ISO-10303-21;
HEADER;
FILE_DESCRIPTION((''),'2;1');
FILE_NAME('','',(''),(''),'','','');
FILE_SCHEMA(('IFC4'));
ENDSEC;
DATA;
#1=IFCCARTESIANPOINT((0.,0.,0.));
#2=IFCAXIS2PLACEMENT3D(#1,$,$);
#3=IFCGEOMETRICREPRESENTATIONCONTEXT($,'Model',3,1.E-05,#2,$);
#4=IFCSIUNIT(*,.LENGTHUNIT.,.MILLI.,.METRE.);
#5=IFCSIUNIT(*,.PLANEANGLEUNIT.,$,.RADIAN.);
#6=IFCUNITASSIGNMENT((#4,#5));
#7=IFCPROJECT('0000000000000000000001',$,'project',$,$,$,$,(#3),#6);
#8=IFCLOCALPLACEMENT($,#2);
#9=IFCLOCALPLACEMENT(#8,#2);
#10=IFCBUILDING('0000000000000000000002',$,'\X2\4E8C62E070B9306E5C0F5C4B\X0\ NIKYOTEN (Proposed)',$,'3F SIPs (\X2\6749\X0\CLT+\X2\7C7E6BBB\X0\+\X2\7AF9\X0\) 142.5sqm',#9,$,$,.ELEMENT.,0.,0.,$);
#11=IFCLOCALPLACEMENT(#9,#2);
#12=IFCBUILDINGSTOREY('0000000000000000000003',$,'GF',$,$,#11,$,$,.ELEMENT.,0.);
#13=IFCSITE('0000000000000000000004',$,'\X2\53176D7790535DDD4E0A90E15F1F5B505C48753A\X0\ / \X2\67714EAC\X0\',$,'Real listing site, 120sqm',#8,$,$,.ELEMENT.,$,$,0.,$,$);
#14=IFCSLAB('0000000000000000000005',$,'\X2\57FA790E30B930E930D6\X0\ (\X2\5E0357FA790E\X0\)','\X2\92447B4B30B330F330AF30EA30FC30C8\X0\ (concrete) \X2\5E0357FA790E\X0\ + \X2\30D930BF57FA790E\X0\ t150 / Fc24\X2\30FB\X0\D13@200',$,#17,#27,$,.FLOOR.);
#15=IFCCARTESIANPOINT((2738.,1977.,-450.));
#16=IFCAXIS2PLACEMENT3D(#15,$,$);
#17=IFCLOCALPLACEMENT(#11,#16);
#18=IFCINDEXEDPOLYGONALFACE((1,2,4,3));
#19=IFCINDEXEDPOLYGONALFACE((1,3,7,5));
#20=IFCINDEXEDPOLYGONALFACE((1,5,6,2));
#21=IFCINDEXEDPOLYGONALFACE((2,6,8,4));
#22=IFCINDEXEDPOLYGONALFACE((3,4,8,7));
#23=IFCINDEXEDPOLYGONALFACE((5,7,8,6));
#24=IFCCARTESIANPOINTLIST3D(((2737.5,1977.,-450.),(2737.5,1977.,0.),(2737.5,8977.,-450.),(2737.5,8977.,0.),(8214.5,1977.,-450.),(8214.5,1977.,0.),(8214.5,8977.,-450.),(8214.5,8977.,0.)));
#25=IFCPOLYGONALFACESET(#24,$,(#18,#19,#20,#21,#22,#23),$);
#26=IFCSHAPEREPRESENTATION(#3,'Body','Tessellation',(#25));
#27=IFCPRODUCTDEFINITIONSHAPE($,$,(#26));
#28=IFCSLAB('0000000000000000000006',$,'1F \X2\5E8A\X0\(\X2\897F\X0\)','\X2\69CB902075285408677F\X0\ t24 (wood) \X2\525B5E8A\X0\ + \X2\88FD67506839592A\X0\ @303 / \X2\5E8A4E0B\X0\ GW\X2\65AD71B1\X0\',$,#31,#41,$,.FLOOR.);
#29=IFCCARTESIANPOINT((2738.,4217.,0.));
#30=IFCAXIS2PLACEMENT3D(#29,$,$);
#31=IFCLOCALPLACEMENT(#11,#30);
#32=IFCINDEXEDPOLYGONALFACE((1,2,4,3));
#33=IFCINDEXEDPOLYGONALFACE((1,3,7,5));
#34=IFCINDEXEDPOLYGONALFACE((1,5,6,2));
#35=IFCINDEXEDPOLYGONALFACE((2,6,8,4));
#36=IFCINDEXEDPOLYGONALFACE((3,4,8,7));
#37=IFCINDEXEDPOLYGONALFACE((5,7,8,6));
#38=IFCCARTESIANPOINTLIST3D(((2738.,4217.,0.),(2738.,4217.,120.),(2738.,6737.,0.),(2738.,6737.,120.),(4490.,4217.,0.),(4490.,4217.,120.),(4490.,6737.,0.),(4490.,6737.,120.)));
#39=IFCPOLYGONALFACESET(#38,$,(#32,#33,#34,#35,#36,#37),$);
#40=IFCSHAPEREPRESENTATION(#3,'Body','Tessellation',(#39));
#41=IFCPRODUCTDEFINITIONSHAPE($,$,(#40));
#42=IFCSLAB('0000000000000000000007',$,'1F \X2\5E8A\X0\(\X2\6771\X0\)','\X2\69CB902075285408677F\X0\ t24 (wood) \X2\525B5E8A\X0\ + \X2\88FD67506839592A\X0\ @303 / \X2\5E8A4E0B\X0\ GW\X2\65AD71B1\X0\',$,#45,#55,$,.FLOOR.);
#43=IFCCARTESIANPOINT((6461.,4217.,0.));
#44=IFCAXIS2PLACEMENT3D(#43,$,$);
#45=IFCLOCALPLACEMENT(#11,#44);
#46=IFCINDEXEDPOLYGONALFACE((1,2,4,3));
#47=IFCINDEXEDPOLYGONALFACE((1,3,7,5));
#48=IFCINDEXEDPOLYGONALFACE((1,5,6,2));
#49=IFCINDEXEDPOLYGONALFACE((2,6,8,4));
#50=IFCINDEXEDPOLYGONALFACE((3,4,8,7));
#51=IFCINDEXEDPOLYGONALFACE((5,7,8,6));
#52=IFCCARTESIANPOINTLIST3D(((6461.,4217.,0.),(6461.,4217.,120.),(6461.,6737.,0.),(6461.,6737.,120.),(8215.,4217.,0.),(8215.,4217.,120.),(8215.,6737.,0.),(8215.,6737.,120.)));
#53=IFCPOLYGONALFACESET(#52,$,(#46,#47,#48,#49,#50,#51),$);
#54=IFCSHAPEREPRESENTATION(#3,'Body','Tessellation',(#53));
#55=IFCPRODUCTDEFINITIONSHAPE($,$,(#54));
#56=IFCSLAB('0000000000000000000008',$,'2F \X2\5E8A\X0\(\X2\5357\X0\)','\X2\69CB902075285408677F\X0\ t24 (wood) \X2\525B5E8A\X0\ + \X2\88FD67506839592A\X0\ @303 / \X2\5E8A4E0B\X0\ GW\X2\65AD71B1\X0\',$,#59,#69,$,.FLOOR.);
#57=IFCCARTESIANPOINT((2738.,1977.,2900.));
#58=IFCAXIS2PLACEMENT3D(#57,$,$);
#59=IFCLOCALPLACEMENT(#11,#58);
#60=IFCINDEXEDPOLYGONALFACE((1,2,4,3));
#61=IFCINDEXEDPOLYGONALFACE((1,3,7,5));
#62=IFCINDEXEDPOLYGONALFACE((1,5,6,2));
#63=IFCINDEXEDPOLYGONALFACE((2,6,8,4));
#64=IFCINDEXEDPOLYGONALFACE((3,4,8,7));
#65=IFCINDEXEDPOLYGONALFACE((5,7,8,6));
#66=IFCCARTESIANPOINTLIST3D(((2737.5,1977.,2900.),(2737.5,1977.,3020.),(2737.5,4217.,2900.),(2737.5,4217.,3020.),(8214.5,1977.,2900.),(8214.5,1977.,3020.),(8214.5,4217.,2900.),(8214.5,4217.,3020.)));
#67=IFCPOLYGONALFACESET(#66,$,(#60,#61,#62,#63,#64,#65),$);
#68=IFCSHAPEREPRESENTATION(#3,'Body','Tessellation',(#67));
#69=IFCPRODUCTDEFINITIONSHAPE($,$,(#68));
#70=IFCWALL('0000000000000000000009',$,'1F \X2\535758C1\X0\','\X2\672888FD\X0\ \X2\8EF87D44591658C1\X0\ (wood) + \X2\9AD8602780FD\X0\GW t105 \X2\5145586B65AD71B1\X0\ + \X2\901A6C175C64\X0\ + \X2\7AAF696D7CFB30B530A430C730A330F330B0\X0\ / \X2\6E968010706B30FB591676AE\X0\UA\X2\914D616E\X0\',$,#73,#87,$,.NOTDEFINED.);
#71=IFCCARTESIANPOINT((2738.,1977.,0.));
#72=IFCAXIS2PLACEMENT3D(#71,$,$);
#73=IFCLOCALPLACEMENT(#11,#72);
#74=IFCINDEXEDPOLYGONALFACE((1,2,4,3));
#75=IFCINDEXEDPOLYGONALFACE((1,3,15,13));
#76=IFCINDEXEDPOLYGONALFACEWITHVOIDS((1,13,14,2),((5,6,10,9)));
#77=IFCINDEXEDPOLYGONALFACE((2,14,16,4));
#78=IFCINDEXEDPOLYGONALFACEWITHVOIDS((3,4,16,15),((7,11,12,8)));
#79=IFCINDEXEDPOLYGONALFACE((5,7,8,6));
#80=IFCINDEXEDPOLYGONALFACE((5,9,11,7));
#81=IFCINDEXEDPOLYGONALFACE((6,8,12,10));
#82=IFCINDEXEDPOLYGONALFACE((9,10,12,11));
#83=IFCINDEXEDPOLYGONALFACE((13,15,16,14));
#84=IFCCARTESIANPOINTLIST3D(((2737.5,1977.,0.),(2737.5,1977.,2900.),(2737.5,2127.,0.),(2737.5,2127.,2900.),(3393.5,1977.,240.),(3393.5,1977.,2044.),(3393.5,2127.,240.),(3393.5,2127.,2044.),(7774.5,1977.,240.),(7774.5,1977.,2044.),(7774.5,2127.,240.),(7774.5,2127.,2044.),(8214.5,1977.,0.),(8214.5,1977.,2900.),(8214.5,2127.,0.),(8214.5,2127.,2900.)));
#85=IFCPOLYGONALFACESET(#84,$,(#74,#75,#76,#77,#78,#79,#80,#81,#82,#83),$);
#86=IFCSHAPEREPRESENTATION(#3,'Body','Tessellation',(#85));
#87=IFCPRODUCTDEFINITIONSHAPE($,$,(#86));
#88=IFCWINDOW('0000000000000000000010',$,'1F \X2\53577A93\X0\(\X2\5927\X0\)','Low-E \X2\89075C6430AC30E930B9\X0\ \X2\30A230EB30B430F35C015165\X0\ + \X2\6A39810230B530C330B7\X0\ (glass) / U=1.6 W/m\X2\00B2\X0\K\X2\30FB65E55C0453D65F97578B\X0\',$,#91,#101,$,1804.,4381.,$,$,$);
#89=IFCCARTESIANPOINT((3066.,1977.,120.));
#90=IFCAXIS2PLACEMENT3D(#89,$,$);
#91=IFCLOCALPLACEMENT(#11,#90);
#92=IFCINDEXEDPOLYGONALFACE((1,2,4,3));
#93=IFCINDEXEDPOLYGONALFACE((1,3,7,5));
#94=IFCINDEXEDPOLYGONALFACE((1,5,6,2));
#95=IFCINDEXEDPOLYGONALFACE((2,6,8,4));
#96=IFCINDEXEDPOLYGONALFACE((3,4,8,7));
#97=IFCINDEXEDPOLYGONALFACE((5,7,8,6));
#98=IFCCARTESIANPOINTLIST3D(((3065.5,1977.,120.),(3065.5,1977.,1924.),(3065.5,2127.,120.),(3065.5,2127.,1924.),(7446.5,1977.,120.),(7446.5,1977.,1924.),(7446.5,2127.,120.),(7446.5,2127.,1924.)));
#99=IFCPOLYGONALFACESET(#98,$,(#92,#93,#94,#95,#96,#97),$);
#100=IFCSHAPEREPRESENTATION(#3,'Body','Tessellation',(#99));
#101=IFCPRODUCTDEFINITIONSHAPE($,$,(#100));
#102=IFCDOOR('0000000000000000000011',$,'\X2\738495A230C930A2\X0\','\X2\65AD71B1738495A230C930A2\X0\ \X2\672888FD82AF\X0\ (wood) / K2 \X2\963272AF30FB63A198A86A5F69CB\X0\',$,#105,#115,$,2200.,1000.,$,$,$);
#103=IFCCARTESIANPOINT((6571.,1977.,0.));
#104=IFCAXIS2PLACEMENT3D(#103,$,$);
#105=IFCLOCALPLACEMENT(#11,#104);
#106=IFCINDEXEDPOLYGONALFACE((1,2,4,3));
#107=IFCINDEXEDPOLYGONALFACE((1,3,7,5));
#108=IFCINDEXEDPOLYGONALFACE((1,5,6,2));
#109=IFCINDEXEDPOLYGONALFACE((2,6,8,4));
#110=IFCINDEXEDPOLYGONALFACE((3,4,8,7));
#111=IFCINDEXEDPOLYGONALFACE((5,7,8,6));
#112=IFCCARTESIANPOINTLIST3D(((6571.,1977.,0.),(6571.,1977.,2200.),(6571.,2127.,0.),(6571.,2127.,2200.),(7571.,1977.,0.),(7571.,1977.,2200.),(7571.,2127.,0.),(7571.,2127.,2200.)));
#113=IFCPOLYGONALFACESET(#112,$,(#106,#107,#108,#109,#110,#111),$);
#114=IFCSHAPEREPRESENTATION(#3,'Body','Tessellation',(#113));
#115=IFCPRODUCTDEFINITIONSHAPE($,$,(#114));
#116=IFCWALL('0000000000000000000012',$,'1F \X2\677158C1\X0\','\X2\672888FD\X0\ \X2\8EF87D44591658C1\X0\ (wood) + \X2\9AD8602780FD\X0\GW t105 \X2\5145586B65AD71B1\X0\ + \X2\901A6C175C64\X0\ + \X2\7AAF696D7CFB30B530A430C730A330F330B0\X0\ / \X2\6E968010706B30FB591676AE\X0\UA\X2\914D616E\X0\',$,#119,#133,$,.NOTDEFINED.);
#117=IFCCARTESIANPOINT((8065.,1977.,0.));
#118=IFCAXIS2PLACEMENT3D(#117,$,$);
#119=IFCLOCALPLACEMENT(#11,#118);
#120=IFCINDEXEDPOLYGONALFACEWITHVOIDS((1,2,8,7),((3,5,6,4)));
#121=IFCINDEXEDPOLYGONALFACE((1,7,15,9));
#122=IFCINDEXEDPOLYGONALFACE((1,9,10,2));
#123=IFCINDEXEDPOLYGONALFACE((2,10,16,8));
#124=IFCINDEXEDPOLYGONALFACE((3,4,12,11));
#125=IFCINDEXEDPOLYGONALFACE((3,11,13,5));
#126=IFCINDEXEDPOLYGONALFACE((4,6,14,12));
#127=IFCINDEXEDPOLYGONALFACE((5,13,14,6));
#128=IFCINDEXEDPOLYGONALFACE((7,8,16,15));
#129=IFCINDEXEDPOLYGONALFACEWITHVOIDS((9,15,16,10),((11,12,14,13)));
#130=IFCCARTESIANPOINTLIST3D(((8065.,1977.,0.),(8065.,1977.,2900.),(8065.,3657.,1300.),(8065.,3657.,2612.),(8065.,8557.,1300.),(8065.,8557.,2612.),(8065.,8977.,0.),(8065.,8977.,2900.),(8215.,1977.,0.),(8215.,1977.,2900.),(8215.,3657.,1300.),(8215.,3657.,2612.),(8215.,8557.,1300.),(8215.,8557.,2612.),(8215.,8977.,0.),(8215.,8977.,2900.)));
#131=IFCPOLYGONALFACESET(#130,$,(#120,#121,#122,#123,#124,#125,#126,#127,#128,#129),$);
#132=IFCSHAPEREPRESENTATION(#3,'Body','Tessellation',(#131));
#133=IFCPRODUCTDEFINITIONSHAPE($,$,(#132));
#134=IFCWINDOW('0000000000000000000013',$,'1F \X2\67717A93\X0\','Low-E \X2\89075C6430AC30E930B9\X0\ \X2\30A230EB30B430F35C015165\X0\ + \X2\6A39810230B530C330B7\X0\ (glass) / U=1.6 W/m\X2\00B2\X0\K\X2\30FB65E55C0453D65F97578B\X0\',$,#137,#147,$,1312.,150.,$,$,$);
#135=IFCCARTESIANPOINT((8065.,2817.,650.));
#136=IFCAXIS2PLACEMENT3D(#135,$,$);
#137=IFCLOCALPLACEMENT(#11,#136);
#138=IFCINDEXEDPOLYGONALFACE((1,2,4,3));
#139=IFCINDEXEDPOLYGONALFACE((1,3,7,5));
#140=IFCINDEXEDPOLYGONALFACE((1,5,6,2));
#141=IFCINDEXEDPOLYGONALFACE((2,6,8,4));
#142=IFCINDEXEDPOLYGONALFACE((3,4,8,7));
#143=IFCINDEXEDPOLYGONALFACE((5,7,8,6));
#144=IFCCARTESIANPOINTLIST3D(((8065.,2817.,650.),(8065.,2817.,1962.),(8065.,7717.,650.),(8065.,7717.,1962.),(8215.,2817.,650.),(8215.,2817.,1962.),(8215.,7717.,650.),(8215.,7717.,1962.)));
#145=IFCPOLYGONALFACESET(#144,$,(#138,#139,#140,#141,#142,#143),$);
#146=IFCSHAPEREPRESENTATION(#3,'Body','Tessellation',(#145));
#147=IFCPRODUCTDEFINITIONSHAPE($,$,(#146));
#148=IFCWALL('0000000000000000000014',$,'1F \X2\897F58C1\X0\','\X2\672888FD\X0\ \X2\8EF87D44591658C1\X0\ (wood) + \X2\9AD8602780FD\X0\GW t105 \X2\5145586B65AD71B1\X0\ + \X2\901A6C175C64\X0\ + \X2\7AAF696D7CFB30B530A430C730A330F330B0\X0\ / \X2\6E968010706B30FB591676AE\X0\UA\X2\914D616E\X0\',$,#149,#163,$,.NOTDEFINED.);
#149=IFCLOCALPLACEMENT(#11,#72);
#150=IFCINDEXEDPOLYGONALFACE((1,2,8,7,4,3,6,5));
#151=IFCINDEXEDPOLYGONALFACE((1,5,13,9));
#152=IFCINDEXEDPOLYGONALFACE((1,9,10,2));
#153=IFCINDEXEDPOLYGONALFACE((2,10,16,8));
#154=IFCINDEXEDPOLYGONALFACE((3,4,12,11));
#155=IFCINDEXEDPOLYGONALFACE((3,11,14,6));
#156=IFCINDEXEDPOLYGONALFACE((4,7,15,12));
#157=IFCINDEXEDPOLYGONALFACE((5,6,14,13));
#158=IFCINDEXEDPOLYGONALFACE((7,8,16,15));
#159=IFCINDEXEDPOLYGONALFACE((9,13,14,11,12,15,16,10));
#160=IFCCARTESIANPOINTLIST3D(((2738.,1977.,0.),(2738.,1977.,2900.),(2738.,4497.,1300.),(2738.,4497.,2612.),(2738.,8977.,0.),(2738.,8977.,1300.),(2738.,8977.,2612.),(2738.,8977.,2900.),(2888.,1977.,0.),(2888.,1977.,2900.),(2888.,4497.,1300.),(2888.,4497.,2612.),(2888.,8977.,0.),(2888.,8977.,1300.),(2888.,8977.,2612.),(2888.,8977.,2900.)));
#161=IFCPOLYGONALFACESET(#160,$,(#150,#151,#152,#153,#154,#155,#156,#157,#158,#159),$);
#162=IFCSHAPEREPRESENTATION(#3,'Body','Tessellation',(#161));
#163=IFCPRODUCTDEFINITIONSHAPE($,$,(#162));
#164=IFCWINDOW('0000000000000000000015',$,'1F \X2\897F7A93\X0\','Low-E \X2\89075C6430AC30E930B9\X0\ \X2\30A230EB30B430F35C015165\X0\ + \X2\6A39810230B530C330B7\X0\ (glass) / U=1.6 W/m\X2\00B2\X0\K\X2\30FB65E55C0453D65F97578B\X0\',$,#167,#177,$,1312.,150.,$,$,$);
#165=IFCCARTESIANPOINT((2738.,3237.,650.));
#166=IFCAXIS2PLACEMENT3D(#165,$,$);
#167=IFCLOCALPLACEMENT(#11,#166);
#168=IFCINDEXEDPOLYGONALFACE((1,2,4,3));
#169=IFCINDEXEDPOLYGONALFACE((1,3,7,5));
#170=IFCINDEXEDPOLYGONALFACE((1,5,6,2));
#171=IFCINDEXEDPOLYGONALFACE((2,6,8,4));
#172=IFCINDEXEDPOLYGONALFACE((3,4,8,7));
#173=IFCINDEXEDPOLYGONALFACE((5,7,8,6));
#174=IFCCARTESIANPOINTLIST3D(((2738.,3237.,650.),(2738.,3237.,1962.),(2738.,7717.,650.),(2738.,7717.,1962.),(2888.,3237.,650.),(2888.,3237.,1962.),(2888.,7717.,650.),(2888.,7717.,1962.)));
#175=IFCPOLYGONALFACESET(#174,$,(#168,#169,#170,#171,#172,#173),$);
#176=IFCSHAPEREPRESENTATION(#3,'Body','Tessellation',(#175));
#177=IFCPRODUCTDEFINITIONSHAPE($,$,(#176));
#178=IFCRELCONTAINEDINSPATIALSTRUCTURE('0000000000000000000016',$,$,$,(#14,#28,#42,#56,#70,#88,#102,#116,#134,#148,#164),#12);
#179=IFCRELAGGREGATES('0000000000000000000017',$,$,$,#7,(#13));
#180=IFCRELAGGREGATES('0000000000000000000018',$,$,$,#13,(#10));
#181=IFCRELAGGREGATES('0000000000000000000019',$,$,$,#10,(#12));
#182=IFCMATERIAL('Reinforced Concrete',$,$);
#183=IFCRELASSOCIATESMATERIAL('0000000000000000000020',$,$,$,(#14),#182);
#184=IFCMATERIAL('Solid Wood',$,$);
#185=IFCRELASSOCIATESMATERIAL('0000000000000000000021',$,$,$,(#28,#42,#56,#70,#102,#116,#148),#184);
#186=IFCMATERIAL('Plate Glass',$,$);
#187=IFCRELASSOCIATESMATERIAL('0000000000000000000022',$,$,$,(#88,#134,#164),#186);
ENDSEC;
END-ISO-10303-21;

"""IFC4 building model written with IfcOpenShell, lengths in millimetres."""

from ifc_helpers import new_model, si_unit, frame, frame_2d, origin, place, context, project, spatial, rectangle, extrude, material, element, fill, save


model = new_model("IFC4")

# Units and contexts
model_context = context("Model", 3, precision=1e-05, world=origin())
ifc_project = project(units=[si_unit("LENGTHUNIT", "METRE", prefix="MILLI"), si_unit("PLANEANGLEUNIT", "RADIAN")], contexts=[model_context])

# Site, building, storey
site_placement = place(None, origin())
site = spatial("IfcSite", under=ifc_project, at=site_placement, Name="北海道川上郡弟子屈町 / 東京", ObjectType="Real listing site, 120sqm", CompositionType="ELEMENT", RefElevation=0.0)
building_placement = place(site_placement, origin())
building = spatial("IfcBuilding", under=site, at=building_placement, Name="二拠点の小屋 NIKYOTEN (Proposed)", ObjectType="3F SIPs (杉CLT+籾殻+竹) 142.5sqm", CompositionType="ELEMENT", ElevationOfRefHeight=0.0, ElevationOfTerrain=0.0)
storey_placement = place(building_placement, origin())
storey = spatial("IfcBuildingStorey", under=building, at=storey_placement, Name="GF", CompositionType="ELEMENT", Elevation=0.0)

# Slabs
ifc_material_1 = material(Name="Reinforced Concrete")
slab_1_placement = place(storey_placement, frame((2738.0, 1977.0, -450.0)))
element("IfcSlab", 1, at=slab_1_placement, inside=storey, material=ifc_material_1, Name="基礎スラブ (布基礎)", Description="鉄筋コンクリート (concrete) 布基礎 + ベタ基礎 t150 / Fc24・D13@200", PredefinedType="FLOOR", context=model_context, shape_type="SweptSolid", body=[
    extrude(rectangle(XDim=5477.0, YDim=7000.0, at=frame_2d((2738.0, 3500.0))), frame((2738.0, 1977.0, -450.0)), (0.0, 0.0, 1.0), 450.0),
])
ifc_material_2 = material(Name="Solid Wood")
slab_2_placement = place(storey_placement, frame((2738.0, 4217.0, 0.0)))
element("IfcSlab", 2, at=slab_2_placement, inside=storey, material=ifc_material_2, Name="1F 床(西)", Description="構造用合板 t24 (wood) 剛床 + 製材根太 @303 / 床下 GW断熱", PredefinedType="FLOOR", context=model_context, shape_type="SweptSolid", body=[
    extrude(rectangle(XDim=1752.0, YDim=2520.0, at=frame_2d((876.0, 1260.0))), frame((2738.0, 4217.0, 0.0)), (0.0, 0.0, 1.0), 120.0),
])
slab_3_placement = place(storey_placement, frame((6461.0, 4217.0, 0.0)))
element("IfcSlab", 3, at=slab_3_placement, inside=storey, material=ifc_material_2, Name="1F 床(東)", Description="構造用合板 t24 (wood) 剛床 + 製材根太 @303 / 床下 GW断熱", PredefinedType="FLOOR", context=model_context, shape_type="SweptSolid", body=[
    extrude(rectangle(XDim=1754.0, YDim=2520.0, at=frame_2d((877.0, 1260.0))), frame((6461.0, 4217.0, 0.0)), (0.0, 0.0, 1.0), 120.0),
])
slab_4_placement = place(storey_placement, frame((2738.0, 1977.0, 2900.0)))
element("IfcSlab", 4, at=slab_4_placement, inside=storey, material=ifc_material_2, Name="2F 床(南)", Description="構造用合板 t24 (wood) 剛床 + 製材根太 @303 / 床下 GW断熱", PredefinedType="FLOOR", context=model_context, shape_type="SweptSolid", body=[
    extrude(rectangle(XDim=5477.0, YDim=2240.0, at=frame_2d((2738.0, 1120.0))), frame((2738.0, 1977.0, 2900.0)), (0.0, 0.0, 1.0), 120.0),
])

# Wall, openings, window, door
wall_1_placement = place(storey_placement, frame((2738.0, 1977.0, 0.0)))
wall_1 = element("IfcWall", 5, at=wall_1_placement, inside=storey, material=ifc_material_2, Name="1F 南壁", Description="木製 軸組外壁 (wood) + 高性能GW t105 充填断熱 + 通気層 + 窯業系サイディング / 準耐火・外皮UA配慮", PredefinedType="NOTDEFINED", context=model_context, shape_type="SweptSolid", body=[
    extrude(rectangle(XDim=5477.0, YDim=150.0, at=frame_2d((2738.0, 75.0))), frame((2738.0, 1977.0, 0.0)), (0.0, 0.0, 1.0), 2900.0),
])
opening_1_placement = place(storey_placement, frame((3066.0, 1977.0, 120.0)))
opening_1 = element("IfcOpeningElement", 6, at=opening_1_placement, cuts=wall_1, PredefinedType="NOTDEFINED", context=model_context, shape_type="SweptSolid", body=[
    extrude(rectangle(XDim=4381.0, YDim=150.0, at=frame_2d((2190.0, 75.0))), frame((3066.0, 1977.0, 120.0)), (0.0, 0.0, 1.0), 1804.0),
])
opening_2_placement = place(storey_placement, frame((6571.0, 1977.0, 0.0)))
opening_2 = element("IfcOpeningElement", 7, at=opening_2_placement, cuts=wall_1, PredefinedType="NOTDEFINED", context=model_context, shape_type="SweptSolid", body=[
    extrude(rectangle(XDim=1000.0, YDim=150.0, at=frame_2d((500.0, 75.0))), frame((6571.0, 1977.0, 0.0)), (0.0, 0.0, 1.0), 2200.0),
])
ifc_material_3 = material(Name="Plate Glass")
window_1_placement = place(storey_placement, frame((3066.0, 1977.0, 120.0)))
window_1 = element("IfcWindow", 8, at=window_1_placement, inside=storey, material=ifc_material_3, Name="1F 南窓(大)", Description="Low-E 複層ガラス アルゴン封入 + 樹脂サッシ (glass) / U=1.6 W/m²K・日射取得型", OverallHeight=1804.0, OverallWidth=4381.0, context=model_context, shape_type="SweptSolid", body=[
    extrude(rectangle(XDim=4381.0, YDim=150.0, at=frame_2d((2190.0, 75.0))), frame((3066.0, 1977.0, 120.0)), (0.0, 0.0, 1.0), 1804.0),
])
fill(opening_1, window_1)
door_placement = place(storey_placement, frame((6571.0, 1977.0, 0.0)))
door = element("IfcDoor", 9, at=door_placement, inside=storey, material=ifc_material_2, Name="玄関ドア", Description="断熱玄関ドア 木製芯 (wood) / K2 防犯・採風機構", OverallHeight=2200.0, OverallWidth=1000.0, context=model_context, shape_type="SweptSolid", body=[
    extrude(rectangle(XDim=1000.0, YDim=150.0, at=frame_2d((500.0, 75.0))), frame((6571.0, 1977.0, 0.0)), (0.0, 0.0, 1.0), 2200.0),
])
fill(opening_2, door)

# Walls, openings, windows
wall_2_placement = place(storey_placement, frame((8065.0, 1977.0, 0.0)))
wall_2 = element("IfcWall", 10, at=wall_2_placement, inside=storey, material=ifc_material_2, Name="1F 東壁", Description="木製 軸組外壁 (wood) + 高性能GW t105 充填断熱 + 通気層 + 窯業系サイディング / 準耐火・外皮UA配慮", PredefinedType="NOTDEFINED", context=model_context, shape_type="SweptSolid", body=[
    extrude(rectangle(XDim=150.0, YDim=7000.0, at=frame_2d((75.0, 3500.0))), frame((8065.0, 1977.0, 0.0)), (0.0, 0.0, 1.0), 2900.0),
])
opening_3_placement = place(storey_placement, frame((8065.0, 2817.0, 650.0)))
opening_3 = element("IfcOpeningElement", 11, at=opening_3_placement, cuts=wall_2, PredefinedType="NOTDEFINED", context=model_context, shape_type="SweptSolid", body=[
    extrude(rectangle(XDim=150.0, YDim=4900.0, at=frame_2d((75.0, 2450.0))), frame((8065.0, 2817.0, 650.0)), (0.0, 0.0, 1.0), 1312.0),
])
window_2_placement = place(storey_placement, frame((8065.0, 2817.0, 650.0)))
window_2 = element("IfcWindow", 12, at=window_2_placement, inside=storey, material=ifc_material_3, Name="1F 東窓", Description="Low-E 複層ガラス アルゴン封入 + 樹脂サッシ (glass) / U=1.6 W/m²K・日射取得型", OverallHeight=1312.0, OverallWidth=150.0, context=model_context, shape_type="SweptSolid", body=[
    extrude(rectangle(XDim=150.0, YDim=4900.0, at=frame_2d((75.0, 2450.0))), frame((8065.0, 2817.0, 650.0)), (0.0, 0.0, 1.0), 1312.0),
])
fill(opening_3, window_2)
wall_3_placement = place(storey_placement, frame((2738.0, 1977.0, 0.0)))
wall_3 = element("IfcWall", 13, at=wall_3_placement, inside=storey, material=ifc_material_2, Name="1F 西壁", Description="木製 軸組外壁 (wood) + 高性能GW t105 充填断熱 + 通気層 + 窯業系サイディング / 準耐火・外皮UA配慮", PredefinedType="NOTDEFINED", context=model_context, shape_type="SweptSolid", body=[
    extrude(rectangle(XDim=150.0, YDim=7000.0, at=frame_2d((75.0, 3500.0))), frame((2738.0, 1977.0, 0.0)), (0.0, 0.0, 1.0), 2900.0),
])
opening_4_placement = place(storey_placement, frame((2738.0, 3237.0, 650.0)))
opening_4 = element("IfcOpeningElement", 14, at=opening_4_placement, cuts=wall_3, PredefinedType="NOTDEFINED", context=model_context, shape_type="SweptSolid", body=[
    extrude(rectangle(XDim=150.0, YDim=4480.0, at=frame_2d((75.0, 2240.0))), frame((2738.0, 3237.0, 650.0)), (0.0, 0.0, 1.0), 1312.0),
])
window_3_placement = place(storey_placement, frame((2738.0, 3237.0, 650.0)))
window_3 = element("IfcWindow", 15, at=window_3_placement, inside=storey, material=ifc_material_3, Name="1F 西窓", Description="Low-E 複層ガラス アルゴン封入 + 樹脂サッシ (glass) / U=1.6 W/m²K・日射取得型", OverallHeight=1312.0, OverallWidth=150.0, context=model_context, shape_type="SweptSolid", body=[
    extrude(rectangle(XDim=150.0, YDim=4480.0, at=frame_2d((75.0, 2240.0))), frame((2738.0, 3237.0, 650.0)), (0.0, 0.0, 1.0), 1312.0),
])
fill(opening_4, window_3)

save(model, "model.ifc")
